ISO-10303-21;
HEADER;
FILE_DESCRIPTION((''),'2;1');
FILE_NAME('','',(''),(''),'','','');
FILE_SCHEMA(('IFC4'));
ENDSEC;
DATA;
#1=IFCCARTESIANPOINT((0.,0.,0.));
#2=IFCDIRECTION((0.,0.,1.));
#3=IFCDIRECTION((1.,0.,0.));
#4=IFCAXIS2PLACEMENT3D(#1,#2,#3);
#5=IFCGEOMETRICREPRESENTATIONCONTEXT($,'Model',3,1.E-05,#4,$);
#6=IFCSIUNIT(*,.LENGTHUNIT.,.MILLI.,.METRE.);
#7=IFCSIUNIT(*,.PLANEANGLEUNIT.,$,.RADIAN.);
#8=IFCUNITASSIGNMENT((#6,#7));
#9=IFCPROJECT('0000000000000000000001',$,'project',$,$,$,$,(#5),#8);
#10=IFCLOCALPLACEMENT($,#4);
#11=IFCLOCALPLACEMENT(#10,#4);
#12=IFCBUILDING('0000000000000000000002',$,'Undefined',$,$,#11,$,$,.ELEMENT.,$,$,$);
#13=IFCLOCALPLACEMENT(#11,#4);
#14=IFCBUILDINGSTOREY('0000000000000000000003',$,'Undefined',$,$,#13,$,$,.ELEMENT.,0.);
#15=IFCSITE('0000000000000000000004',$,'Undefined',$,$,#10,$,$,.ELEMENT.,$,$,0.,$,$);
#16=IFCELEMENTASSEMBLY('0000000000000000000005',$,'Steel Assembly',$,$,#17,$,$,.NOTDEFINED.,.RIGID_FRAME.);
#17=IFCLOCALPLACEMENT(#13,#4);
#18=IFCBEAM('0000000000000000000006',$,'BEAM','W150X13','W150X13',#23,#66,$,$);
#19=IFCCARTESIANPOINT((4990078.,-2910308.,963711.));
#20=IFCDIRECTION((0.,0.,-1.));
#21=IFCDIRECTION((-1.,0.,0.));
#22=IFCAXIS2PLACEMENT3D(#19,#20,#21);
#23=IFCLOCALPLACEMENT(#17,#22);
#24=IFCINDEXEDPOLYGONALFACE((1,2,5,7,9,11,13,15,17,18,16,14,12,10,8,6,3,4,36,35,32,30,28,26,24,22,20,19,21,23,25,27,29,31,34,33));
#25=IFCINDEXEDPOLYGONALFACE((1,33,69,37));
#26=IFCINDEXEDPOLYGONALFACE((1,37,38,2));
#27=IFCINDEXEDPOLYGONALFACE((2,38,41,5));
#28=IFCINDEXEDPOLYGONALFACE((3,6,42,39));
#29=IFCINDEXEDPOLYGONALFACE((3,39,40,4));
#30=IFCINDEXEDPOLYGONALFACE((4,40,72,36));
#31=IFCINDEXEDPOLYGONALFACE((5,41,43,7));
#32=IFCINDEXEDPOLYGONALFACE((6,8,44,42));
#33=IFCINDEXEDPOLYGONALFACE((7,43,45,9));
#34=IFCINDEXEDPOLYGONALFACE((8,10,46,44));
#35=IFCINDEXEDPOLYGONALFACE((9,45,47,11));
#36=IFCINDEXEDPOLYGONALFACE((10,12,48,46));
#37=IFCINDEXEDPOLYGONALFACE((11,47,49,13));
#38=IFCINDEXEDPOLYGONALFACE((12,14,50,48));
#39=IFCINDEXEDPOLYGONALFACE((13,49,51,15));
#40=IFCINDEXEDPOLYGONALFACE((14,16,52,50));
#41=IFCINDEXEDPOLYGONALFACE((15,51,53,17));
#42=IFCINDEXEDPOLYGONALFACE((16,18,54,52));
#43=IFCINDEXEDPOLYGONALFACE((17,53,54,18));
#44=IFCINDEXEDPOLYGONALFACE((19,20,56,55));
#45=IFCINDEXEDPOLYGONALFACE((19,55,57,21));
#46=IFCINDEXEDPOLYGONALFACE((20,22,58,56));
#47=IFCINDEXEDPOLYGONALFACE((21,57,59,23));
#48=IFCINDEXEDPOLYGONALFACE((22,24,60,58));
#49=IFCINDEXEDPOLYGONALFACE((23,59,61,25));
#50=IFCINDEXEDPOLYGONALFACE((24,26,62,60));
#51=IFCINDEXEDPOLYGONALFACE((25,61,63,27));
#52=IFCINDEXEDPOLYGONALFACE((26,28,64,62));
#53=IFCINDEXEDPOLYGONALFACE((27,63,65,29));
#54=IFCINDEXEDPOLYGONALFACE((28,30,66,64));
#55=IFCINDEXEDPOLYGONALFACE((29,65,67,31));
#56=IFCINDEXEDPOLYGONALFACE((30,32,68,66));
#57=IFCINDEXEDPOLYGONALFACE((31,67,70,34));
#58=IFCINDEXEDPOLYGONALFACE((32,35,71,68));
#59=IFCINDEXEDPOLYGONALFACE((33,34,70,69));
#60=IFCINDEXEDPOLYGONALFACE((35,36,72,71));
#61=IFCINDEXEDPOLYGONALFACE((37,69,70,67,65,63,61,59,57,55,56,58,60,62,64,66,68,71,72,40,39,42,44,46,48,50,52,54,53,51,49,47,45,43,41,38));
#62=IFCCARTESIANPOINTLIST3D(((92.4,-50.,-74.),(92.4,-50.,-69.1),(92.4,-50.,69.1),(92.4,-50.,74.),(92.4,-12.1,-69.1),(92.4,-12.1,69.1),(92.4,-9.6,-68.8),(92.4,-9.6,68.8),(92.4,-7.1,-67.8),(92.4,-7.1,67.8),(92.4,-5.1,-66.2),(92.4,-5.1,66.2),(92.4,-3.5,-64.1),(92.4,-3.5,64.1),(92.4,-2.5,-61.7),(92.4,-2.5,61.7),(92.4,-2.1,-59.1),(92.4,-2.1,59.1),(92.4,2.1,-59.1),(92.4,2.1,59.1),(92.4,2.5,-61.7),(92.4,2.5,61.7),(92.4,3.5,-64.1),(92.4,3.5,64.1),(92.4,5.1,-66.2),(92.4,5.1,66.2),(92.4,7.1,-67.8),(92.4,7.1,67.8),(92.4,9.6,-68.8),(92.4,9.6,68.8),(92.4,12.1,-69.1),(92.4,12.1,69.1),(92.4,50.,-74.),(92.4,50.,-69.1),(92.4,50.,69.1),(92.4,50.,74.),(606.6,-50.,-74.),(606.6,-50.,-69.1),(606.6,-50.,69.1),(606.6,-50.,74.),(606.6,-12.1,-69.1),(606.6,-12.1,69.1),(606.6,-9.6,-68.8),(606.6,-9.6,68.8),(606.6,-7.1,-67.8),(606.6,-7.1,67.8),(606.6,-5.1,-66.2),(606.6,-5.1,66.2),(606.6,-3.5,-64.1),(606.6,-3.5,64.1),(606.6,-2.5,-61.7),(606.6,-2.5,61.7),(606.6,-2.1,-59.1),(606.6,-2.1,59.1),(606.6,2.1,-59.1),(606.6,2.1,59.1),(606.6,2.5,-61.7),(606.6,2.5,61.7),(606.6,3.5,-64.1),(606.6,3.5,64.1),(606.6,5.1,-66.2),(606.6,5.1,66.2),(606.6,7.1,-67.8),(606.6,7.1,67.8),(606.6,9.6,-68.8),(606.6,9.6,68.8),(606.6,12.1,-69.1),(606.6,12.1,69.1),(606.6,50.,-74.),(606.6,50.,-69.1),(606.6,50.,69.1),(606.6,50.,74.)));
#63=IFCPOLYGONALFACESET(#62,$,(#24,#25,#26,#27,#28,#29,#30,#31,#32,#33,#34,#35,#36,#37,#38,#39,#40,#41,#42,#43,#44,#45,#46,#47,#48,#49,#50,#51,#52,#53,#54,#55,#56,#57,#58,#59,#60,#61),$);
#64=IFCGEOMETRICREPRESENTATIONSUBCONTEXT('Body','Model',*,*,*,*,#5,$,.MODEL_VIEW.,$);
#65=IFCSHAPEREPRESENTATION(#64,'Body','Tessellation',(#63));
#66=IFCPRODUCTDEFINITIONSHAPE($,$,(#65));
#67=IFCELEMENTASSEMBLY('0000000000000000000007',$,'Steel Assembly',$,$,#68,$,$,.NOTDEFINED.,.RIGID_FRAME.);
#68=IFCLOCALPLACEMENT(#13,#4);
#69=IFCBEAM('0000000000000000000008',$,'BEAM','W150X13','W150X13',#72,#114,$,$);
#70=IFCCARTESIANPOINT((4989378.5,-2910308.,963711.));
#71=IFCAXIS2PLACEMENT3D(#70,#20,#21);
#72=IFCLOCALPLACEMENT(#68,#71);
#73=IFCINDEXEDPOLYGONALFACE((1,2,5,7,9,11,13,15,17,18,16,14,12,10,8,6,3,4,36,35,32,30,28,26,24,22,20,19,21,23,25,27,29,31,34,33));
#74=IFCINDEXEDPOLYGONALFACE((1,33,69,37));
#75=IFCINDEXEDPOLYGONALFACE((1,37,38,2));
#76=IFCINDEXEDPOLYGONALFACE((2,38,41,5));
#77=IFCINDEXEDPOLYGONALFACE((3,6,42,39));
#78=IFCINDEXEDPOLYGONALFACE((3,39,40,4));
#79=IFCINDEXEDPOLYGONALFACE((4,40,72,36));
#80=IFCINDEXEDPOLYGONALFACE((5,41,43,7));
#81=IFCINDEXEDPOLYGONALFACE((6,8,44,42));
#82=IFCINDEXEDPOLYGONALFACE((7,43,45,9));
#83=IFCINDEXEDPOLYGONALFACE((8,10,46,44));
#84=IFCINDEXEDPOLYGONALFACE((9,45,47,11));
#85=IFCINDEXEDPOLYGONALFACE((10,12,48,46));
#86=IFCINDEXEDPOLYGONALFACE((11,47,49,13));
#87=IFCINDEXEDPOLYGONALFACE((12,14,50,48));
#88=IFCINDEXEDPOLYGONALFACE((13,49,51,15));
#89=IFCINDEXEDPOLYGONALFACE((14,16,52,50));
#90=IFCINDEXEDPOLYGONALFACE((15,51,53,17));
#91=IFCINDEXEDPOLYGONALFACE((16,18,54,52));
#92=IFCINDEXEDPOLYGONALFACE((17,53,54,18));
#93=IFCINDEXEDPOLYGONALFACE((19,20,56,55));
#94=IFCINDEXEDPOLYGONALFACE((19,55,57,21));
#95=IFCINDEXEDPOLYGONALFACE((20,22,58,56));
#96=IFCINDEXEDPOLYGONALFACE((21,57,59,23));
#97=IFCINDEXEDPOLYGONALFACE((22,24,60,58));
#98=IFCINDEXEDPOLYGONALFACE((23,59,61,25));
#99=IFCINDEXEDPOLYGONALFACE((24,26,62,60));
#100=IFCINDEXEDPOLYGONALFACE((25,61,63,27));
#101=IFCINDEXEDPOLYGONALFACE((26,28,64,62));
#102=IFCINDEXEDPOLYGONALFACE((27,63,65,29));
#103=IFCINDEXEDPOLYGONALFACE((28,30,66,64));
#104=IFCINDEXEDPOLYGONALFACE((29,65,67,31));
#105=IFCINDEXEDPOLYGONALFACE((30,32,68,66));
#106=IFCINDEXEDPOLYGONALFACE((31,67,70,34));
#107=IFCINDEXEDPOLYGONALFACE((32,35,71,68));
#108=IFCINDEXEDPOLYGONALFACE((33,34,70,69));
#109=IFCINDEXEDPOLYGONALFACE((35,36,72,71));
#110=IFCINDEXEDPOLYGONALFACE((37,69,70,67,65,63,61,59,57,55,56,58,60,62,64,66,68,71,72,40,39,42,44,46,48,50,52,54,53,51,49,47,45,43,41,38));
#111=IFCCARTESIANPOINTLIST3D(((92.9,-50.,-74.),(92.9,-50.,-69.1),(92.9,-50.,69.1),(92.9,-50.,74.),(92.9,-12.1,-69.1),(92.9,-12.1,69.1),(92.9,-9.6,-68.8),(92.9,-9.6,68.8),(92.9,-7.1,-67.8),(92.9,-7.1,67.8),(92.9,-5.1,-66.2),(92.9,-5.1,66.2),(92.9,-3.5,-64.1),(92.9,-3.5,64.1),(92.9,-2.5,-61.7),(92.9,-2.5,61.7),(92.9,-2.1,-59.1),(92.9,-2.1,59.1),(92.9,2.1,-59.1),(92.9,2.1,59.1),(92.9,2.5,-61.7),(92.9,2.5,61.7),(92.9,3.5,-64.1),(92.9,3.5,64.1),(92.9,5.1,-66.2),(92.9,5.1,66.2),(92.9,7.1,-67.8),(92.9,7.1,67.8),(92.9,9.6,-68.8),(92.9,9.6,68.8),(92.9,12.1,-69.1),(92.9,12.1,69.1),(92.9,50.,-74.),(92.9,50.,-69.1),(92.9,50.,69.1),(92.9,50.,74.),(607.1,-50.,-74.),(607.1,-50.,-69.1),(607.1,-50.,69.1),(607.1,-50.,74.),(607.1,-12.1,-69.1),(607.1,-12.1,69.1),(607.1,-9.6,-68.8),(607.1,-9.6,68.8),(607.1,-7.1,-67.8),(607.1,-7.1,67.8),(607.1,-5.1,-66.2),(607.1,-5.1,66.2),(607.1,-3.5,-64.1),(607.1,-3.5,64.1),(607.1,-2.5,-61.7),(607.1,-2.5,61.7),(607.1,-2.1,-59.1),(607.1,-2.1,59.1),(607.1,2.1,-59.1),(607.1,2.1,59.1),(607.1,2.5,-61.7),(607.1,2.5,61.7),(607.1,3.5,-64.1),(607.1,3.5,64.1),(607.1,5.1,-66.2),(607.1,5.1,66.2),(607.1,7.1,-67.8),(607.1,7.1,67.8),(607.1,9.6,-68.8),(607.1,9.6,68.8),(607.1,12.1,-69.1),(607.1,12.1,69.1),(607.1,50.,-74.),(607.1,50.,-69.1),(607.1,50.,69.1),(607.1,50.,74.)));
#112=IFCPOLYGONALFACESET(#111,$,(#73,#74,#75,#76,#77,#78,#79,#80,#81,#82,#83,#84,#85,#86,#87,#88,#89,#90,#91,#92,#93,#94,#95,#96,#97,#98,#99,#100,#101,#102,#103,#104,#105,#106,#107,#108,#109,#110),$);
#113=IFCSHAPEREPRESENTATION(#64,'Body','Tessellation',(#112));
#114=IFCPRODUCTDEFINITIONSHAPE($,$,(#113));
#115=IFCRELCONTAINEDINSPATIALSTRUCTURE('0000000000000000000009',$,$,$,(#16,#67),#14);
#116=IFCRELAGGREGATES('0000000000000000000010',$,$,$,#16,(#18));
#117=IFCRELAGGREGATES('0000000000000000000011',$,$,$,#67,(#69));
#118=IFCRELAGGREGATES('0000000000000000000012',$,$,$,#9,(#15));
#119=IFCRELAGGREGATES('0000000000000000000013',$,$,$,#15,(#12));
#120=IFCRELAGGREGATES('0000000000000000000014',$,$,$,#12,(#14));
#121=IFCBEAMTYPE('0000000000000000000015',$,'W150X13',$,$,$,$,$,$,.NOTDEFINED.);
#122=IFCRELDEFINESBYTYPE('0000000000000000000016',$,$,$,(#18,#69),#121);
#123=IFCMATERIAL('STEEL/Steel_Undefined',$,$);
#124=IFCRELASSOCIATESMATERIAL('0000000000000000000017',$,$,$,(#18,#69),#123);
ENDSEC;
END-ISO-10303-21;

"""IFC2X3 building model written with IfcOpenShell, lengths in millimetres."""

from ifc_helpers import new_model, si_unit, frame, origin_with_axes, origin_2d_with_axis, place, context, subcontext, project, spatial, i_section, extrude, clip, halfspace, material, type_object, element, aggregate, save


model = new_model("IFC2X3")

# Units and contexts
model_context = context("Model", 3, precision=1e-05, world=origin_with_axes())
body_context = subcontext(model_context, "Body", "Model", "MODEL_VIEW")
ifc_project = project(units=[si_unit("LENGTHUNIT", "METRE", prefix="MILLI"), si_unit("PLANEANGLEUNIT", "RADIAN")], contexts=[model_context])

# Site, building, storey
site_placement = place(None, origin_with_axes())
site = spatial("IfcSite", under=ifc_project, at=site_placement, Name="Undefined", CompositionType="ELEMENT", RefElevation=0.0)
building_placement = place(site_placement, origin_with_axes())
building = spatial("IfcBuilding", under=site, at=building_placement, Name="Undefined", CompositionType="ELEMENT")
storey_placement = place(building_placement, origin_with_axes())
storey = spatial("IfcBuildingStorey", under=building, at=storey_placement, Name="Undefined", CompositionType="ELEMENT", Elevation=0.0)

# Element assemblies, beams
assembly_1_placement = place(storey_placement, origin_with_axes())
assembly_1 = element("IfcElementAssembly", 1, at=assembly_1_placement, inside=storey, Name="Steel Assembly", AssemblyPlace="NOTDEFINED", PredefinedType="RIGID_FRAME")
ifc_material_1 = material(Name="STEEL/Steel_Undefined")
beam_type = type_object("IfcBeamType", Name="W150X13", PredefinedType="NOTDEFINED")
beam_1_placement = place(assembly_1_placement, frame((4990078.0, -2910308.0, 963711.0), z_axis=(0.0, 0.0, -1.0), x_axis=(-1.0, 0.0, 0.0)))
beam_1 = element("IfcBeam", 2, at=beam_1_placement, type_object=beam_type, material=ifc_material_1, Name="BEAM", Description="W150X13", ObjectType="W150X13", context=body_context, shape_type="Clipping", body=[
    clip(clip(extrude(i_section(OverallWidth=100.0, OverallDepth=148.0, WebThickness=4.3, FlangeThickness=4.9, FilletRadius=10.0, at=origin_2d_with_axis()), frame((606.6, 0.0, 0.0), z_axis=(-1.0, 0.0, 0.0), x_axis=(0.0, -1.0, 0.0)), (0.0, 0.0, 1.0), 514.2), halfspace(frame((606.6, 0.0, -74.0), z_axis=(-1.0, 0.0, 0.0), x_axis=(0.0, 1.0, 0.0)), True)), halfspace(frame((92.4, 0.0, -74.0), z_axis=(1.0, 0.0, 0.0), x_axis=(0.0, -1.0, 0.0)), True)),
])
assembly_2_placement = place(storey_placement, origin_with_axes())
assembly_2 = element("IfcElementAssembly", 3, at=assembly_2_placement, inside=storey, Name="Steel Assembly", AssemblyPlace="NOTDEFINED", PredefinedType="RIGID_FRAME")
beam_2_placement = place(assembly_2_placement, frame((4989378.5, -2910308.0, 963711.0), z_axis=(0.0, 0.0, -1.0), x_axis=(-1.0, 0.0, 0.0)))
beam_2 = element("IfcBeam", 4, at=beam_2_placement, type_object=beam_type, material=ifc_material_1, Name="BEAM", Description="W150X13", ObjectType="W150X13", context=body_context, shape_type="Clipping", body=[
    clip(clip(extrude(i_section(OverallWidth=100.0, OverallDepth=148.0, WebThickness=4.3, FlangeThickness=4.9, FilletRadius=10.0, at=origin_2d_with_axis()), frame((607.1, 0.0, 0.0), z_axis=(-1.0, 0.0, 0.0), x_axis=(0.0, -1.0, 0.0)), (0.0, 0.0, 1.0), 514.2), halfspace(frame((607.1, 0.0, -74.0), z_axis=(-1.0, 0.0, 0.0), x_axis=(0.0, 1.0, 0.0)), True)), halfspace(frame((92.9, 0.0, -74.0), z_axis=(1.0, 0.0, 0.0), x_axis=(0.0, -1.0, 0.0)), True)),
])

aggregate(assembly_1, [beam_1])
aggregate(assembly_2, [beam_2])

save(model, "model.ifc")
